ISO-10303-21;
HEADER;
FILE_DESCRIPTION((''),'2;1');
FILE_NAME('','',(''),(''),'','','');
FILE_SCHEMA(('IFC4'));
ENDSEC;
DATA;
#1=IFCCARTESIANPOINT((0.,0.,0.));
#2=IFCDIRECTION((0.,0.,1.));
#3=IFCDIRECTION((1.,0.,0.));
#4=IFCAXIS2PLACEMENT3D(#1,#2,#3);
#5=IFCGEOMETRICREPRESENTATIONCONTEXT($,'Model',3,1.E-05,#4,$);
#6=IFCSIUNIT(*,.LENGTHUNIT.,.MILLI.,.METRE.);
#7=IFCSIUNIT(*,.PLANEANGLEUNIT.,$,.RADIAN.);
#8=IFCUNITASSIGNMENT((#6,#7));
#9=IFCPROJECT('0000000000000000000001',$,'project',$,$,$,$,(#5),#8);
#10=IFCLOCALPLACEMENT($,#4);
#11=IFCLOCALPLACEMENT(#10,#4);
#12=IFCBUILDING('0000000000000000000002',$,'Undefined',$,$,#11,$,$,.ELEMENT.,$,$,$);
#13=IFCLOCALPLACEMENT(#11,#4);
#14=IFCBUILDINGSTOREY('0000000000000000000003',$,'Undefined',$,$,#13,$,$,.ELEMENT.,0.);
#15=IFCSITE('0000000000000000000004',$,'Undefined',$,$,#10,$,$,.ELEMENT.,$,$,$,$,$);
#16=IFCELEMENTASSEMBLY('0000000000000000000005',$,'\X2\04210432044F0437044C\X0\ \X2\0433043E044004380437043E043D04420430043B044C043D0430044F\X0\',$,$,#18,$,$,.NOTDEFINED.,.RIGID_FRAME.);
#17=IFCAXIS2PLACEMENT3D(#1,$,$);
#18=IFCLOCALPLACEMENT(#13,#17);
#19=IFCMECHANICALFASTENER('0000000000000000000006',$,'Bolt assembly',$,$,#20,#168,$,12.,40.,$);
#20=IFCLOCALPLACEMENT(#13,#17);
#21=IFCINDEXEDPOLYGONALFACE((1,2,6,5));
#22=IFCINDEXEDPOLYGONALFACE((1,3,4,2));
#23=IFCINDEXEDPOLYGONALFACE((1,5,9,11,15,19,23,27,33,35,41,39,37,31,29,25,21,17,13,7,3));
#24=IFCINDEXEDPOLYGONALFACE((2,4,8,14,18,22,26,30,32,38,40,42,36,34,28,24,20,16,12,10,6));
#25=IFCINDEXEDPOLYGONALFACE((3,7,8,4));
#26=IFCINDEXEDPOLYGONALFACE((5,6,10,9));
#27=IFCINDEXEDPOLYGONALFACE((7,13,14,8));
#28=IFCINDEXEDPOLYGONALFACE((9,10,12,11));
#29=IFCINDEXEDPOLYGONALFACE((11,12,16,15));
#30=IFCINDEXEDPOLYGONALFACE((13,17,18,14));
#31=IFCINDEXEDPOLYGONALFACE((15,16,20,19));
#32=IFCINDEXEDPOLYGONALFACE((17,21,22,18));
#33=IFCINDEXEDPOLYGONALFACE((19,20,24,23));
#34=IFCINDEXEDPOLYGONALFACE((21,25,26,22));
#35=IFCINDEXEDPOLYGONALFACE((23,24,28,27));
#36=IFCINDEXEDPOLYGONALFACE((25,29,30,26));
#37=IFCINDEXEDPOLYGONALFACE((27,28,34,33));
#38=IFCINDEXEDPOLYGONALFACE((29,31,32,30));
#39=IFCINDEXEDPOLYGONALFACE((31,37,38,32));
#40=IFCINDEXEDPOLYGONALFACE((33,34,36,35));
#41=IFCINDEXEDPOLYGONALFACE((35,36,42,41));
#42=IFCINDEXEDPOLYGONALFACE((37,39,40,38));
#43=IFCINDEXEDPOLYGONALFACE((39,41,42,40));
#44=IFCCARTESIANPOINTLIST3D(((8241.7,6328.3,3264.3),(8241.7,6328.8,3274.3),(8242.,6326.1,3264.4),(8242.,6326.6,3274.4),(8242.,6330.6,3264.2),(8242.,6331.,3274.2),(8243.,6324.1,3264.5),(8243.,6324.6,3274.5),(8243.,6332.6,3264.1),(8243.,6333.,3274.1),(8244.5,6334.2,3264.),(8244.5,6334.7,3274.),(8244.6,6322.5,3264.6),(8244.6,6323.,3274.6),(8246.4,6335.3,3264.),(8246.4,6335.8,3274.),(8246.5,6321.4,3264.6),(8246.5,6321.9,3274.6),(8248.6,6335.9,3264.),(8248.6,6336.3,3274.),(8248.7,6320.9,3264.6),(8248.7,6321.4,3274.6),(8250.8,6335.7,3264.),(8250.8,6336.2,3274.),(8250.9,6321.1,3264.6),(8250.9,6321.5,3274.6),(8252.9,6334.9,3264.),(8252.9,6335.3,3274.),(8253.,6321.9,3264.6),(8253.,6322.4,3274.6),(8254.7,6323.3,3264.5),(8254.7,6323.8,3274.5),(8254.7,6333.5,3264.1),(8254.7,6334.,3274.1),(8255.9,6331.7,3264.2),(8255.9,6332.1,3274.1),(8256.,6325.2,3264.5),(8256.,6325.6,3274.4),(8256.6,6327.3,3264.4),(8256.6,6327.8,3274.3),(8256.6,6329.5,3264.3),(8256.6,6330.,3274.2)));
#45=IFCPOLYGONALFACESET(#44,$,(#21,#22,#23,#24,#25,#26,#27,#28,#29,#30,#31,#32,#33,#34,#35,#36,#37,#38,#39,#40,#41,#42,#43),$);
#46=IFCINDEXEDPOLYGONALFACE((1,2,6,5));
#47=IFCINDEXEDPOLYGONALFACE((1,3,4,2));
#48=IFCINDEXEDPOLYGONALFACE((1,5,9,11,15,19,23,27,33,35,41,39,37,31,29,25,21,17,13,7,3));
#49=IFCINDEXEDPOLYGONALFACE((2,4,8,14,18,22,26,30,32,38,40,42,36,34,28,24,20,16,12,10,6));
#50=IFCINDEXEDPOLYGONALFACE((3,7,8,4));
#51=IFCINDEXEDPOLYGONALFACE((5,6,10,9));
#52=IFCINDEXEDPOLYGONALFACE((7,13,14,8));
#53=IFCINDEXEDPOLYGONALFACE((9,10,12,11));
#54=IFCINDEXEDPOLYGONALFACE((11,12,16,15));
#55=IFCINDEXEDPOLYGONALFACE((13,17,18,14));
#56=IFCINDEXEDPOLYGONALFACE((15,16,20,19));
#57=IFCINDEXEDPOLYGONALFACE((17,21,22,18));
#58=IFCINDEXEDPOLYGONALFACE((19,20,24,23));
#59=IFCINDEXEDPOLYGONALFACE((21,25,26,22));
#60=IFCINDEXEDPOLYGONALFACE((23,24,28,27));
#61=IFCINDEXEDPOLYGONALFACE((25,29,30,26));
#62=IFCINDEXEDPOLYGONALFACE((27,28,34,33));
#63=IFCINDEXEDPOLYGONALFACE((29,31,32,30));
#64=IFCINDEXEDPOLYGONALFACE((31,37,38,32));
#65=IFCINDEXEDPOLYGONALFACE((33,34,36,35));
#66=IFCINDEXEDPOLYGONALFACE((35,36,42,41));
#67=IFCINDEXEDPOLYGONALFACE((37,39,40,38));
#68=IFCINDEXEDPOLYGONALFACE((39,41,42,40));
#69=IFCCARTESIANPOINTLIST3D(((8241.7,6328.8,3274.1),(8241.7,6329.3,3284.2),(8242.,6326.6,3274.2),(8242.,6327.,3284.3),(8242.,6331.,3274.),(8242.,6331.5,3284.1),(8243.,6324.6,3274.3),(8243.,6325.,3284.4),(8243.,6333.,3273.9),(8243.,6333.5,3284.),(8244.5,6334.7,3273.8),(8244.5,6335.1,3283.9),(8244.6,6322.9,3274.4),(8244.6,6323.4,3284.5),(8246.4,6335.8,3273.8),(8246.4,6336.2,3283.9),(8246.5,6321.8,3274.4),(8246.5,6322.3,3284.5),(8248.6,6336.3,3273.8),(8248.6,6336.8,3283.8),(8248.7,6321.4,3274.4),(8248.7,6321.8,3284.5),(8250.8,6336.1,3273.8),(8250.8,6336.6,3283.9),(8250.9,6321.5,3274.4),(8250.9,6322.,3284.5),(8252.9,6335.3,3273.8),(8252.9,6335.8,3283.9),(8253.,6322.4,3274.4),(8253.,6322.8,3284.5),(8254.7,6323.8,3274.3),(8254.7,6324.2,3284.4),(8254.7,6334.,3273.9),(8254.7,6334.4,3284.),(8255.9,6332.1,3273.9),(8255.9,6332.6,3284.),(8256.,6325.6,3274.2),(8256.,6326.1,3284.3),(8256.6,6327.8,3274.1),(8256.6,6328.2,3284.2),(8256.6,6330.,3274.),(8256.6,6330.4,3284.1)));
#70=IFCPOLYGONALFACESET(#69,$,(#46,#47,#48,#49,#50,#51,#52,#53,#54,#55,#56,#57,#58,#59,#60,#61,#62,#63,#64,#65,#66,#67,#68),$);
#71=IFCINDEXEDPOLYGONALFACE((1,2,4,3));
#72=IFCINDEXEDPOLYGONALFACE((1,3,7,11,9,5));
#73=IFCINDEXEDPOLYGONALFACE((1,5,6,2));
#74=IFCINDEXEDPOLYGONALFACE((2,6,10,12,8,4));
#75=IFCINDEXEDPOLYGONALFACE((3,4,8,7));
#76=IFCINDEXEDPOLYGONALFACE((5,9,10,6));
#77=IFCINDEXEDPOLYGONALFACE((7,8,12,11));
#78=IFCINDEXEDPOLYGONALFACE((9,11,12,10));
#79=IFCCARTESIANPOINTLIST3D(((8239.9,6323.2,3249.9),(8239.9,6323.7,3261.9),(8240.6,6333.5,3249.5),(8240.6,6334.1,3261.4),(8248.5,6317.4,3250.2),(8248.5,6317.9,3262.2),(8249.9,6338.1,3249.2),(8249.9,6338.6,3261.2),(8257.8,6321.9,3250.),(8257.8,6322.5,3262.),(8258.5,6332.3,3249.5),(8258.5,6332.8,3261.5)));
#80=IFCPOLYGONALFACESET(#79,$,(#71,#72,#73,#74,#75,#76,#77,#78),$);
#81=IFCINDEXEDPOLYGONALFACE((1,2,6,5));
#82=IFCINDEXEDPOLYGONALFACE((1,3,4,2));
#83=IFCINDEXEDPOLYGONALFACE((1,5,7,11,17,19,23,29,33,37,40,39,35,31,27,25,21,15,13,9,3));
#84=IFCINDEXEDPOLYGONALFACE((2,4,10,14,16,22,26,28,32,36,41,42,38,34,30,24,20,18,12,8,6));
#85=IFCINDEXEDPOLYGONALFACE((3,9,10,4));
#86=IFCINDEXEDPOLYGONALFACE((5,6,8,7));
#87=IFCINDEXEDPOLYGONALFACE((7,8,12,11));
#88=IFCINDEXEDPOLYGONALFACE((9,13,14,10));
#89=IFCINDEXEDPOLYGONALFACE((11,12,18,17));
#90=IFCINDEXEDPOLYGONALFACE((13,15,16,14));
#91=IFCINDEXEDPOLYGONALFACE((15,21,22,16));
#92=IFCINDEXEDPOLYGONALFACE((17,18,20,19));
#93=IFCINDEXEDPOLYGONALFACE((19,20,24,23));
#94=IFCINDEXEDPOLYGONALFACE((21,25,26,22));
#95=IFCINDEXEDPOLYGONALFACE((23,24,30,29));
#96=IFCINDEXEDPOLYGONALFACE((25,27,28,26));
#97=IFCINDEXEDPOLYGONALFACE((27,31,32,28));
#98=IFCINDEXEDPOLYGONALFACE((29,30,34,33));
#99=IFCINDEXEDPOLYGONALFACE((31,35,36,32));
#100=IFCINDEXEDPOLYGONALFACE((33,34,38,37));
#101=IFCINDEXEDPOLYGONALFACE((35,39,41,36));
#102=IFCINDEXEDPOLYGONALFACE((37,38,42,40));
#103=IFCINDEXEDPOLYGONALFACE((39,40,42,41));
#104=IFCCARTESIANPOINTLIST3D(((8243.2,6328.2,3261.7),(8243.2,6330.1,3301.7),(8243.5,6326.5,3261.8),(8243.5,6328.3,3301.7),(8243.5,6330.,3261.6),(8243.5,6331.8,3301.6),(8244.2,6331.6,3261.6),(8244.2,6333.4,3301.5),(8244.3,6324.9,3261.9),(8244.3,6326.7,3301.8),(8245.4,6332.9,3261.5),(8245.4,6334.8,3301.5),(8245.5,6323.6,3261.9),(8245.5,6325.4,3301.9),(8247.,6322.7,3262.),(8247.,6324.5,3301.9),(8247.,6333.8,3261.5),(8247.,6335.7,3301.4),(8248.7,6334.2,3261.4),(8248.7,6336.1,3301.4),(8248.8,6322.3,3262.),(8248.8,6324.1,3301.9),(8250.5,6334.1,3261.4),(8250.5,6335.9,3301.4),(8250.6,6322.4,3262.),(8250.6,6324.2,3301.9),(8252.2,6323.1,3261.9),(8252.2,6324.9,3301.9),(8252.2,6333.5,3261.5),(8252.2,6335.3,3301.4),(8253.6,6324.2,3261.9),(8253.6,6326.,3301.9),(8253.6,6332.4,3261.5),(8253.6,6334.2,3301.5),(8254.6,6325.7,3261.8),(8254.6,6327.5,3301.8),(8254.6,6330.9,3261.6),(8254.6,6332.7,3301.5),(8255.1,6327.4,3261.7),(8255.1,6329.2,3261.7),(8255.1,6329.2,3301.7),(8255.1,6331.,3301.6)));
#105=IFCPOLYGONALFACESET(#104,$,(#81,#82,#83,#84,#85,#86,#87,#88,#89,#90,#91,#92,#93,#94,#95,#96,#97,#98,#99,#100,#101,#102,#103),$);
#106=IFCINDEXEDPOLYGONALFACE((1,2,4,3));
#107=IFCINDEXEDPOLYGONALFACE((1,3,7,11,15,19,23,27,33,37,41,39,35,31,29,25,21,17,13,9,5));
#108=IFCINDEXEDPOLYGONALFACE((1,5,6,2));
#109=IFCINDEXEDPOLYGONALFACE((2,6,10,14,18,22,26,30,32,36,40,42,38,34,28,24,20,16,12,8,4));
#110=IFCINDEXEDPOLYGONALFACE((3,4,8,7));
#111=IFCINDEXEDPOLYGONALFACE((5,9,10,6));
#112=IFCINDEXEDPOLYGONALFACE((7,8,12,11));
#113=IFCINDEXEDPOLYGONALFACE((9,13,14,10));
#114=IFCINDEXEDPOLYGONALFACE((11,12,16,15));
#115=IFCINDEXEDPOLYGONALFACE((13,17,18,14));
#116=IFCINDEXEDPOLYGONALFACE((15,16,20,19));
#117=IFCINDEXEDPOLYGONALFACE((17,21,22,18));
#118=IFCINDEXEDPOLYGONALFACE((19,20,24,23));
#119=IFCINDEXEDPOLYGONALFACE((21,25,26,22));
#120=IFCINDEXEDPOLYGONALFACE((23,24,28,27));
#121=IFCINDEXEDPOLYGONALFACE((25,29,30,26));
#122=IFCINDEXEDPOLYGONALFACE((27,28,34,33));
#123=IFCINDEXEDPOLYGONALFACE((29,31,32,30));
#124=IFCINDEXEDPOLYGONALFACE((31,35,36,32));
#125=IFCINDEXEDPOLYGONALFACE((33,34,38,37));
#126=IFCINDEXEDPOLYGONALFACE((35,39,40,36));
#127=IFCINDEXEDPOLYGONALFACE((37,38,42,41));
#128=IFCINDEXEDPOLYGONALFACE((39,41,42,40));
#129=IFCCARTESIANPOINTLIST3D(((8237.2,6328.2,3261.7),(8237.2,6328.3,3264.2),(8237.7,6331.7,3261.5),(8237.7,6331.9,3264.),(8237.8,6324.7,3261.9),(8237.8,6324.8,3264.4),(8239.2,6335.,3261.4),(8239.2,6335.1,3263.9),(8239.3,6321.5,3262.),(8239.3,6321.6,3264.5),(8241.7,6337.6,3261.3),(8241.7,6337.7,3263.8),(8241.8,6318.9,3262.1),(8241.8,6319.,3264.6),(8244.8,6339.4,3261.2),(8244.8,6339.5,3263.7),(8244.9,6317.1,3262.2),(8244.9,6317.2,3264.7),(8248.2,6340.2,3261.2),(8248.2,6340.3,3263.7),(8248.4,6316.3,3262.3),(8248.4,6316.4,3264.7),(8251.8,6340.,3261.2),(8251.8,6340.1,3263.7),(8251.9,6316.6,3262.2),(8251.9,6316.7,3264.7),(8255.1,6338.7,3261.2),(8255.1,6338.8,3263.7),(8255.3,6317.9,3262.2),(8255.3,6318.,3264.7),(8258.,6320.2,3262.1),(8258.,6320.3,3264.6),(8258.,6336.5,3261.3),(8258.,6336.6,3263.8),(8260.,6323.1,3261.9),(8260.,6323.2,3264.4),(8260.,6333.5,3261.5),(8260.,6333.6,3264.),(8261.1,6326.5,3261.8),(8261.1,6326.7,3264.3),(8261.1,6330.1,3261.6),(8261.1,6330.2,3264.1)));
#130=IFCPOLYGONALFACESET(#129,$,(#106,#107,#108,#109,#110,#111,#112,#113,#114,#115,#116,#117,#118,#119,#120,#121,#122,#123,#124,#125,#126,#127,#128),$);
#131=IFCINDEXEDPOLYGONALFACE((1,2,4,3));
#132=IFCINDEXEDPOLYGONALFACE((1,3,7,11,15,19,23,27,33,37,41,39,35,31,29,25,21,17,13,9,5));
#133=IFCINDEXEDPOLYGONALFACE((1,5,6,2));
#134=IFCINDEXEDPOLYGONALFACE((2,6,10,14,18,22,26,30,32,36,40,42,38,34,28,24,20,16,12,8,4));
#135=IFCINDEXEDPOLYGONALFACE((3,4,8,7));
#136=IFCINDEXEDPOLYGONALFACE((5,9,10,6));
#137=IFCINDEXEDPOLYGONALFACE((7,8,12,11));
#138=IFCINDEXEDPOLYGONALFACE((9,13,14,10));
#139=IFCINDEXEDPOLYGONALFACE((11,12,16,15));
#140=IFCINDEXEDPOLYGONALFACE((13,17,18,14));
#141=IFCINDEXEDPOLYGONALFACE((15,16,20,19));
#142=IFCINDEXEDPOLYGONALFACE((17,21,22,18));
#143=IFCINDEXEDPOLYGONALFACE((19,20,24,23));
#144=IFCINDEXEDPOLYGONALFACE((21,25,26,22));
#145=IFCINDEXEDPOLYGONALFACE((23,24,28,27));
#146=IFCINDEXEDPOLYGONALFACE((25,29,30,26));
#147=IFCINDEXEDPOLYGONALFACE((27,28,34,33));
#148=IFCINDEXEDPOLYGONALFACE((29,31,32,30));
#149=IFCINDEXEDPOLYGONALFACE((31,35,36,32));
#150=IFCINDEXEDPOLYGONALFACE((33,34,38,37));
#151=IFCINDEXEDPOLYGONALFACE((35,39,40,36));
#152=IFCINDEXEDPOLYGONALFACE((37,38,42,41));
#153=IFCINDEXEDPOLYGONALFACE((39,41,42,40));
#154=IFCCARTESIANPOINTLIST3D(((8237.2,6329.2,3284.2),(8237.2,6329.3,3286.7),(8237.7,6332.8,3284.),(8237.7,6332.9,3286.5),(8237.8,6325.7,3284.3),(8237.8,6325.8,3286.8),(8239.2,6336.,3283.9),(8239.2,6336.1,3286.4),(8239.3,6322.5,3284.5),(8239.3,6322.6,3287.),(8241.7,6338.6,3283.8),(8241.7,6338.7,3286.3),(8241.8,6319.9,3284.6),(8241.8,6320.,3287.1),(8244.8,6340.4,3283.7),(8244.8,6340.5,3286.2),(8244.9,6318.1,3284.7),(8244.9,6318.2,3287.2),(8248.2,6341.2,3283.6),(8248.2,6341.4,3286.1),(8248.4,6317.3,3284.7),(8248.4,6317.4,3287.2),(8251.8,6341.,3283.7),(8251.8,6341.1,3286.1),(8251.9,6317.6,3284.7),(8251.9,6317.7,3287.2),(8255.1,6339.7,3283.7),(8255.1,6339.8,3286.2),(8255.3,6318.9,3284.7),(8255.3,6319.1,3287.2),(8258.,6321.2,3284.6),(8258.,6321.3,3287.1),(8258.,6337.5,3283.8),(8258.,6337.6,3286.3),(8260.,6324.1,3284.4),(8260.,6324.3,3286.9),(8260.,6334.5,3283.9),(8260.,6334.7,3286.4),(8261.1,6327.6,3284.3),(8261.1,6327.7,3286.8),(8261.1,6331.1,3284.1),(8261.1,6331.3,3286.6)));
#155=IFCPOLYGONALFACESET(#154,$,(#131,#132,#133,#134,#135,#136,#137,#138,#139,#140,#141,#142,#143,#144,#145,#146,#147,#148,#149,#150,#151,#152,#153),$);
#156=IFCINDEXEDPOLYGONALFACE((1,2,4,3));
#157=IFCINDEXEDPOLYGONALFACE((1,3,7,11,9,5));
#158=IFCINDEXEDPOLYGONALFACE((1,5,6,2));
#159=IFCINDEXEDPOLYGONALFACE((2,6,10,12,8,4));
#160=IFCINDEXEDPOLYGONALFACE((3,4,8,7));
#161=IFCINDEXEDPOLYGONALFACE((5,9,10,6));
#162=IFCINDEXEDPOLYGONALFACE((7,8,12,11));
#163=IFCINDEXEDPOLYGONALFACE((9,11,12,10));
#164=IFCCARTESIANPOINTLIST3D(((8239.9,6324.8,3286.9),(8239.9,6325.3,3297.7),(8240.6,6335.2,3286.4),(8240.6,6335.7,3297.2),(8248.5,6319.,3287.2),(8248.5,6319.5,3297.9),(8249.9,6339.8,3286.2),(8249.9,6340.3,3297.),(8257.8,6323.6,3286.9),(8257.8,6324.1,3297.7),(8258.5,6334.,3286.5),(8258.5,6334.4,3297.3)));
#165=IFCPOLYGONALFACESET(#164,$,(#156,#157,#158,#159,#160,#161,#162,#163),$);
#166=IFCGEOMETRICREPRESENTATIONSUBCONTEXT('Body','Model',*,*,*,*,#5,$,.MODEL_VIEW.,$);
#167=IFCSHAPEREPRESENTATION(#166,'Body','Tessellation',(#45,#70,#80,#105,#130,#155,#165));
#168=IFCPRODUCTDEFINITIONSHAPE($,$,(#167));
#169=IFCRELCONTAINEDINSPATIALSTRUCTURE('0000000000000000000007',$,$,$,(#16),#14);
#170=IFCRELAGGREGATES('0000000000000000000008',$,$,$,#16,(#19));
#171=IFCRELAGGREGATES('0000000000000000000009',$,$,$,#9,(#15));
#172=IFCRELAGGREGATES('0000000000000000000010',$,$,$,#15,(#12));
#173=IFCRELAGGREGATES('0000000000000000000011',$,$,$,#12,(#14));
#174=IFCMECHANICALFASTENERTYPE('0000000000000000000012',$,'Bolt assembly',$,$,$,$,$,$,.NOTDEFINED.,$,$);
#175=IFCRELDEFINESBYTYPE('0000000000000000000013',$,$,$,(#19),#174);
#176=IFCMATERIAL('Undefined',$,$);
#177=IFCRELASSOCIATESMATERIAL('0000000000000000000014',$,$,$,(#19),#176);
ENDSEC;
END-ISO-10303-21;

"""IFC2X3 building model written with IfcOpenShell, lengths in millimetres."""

from ifc_helpers import new_model, si_unit, frame, origin_with_axes, origin_2d_with_axis, place, context, subcontext, project, spatial, polyline, circle, outline, extrude, source, transform, mapped, material, type_object, element, aggregate, save


model = new_model("IFC2X3")

# Units and contexts
model_context = context("Model", 3, precision=1e-05, world=origin_with_axes())
body_context = subcontext(model_context, "Body", "Model", "MODEL_VIEW")
ifc_project = project(units=[si_unit("LENGTHUNIT", "METRE", prefix="MILLI"), si_unit("PLANEANGLEUNIT", "RADIAN")], contexts=[model_context])

# Site, building, storey
site_placement = place(None, origin_with_axes())
site = spatial("IfcSite", under=ifc_project, at=site_placement, Name="Undefined", CompositionType="ELEMENT")
building_placement = place(site_placement, origin_with_axes())
building = spatial("IfcBuilding", under=site, at=building_placement, Name="Undefined", CompositionType="ELEMENT")
storey_placement = place(building_placement, origin_with_axes())
storey = spatial("IfcBuildingStorey", under=building, at=storey_placement, Name="Undefined", CompositionType="ELEMENT", Elevation=0.0)

# Element assembly
assembly_1_placement = place(storey_placement, origin_with_axes())
assembly_1 = element("IfcElementAssembly", 1, at=assembly_1_placement, inside=storey, Name="Связь горизонтальная", AssemblyPlace="NOTDEFINED", PredefinedType="RIGID_FRAME")

# Mechanical fastener
ifc_material_1 = material(Name="Undefined")
mechanical_fastener_type = type_object("IfcMechanicalFastenerType", Name="Bolt assembly")
shared_shape_1 = source(origin_with_axes(), body_context, "Body", "SweptSolid", [
    extrude(circle(Radius=7.5, at=origin_2d_with_axis()), frame((0.0, 0.1, 0.0), z_axis=(0.0, 1.0, 0.0), x_axis=(1.0, 0.0, 0.0)), (0.0, 0.0, 1.0), 10.0),
    extrude(circle(Radius=7.5, at=origin_2d_with_axis()), frame((0.0, 9.9, 0.0), z_axis=(0.0, 1.0, 0.0), x_axis=(1.0, 0.0, 0.0)), (0.0, 0.0, 1.0), 10.1),
    extrude(outline(polyline([(10.4, 0.0), (5.2, 9.0), (-5.2, 9.0), (-10.4, 0.0), (-5.2, -9.0), (5.2, -9.0), (10.4, 0.0)])), frame((0.0, -14.5, 0.0), z_axis=(0.0, 1.0, 0.0), x_axis=(1.0, 0.0, 0.0)), (0.0, 0.0, 1.0), 12.0),
    extrude(circle(Radius=6.0, at=origin_2d_with_axis()), frame((0.0, -2.5, 0.0), z_axis=(0.0, 1.0, 0.0), x_axis=(1.0, 0.0, 0.0)), (0.0, 0.0, 1.0), 40.0),
    extrude(circle(Radius=12.0, at=origin_2d_with_axis()), frame((0.0, -2.5, 0.0), z_axis=(0.0, 1.0, 0.0), x_axis=(1.0, 0.0, 0.0)), (0.0, 0.0, 1.0), 2.5),
    extrude(circle(Radius=12.0, at=origin_2d_with_axis()), frame((0.0, 20.0, 0.0), z_axis=(0.0, 1.0, 0.0), x_axis=(1.0, 0.0, 0.0)), (0.0, 0.0, 1.0), 2.5),
    extrude(outline(polyline([(10.4, 0.0), (5.2, 9.0), (-5.2, 9.0), (-10.4, 0.0), (-5.2, -9.0), (5.2, -9.0), (10.4, 0.0)])), frame((0.0, 22.5, 0.0), z_axis=(0.0, 1.0, 0.0), x_axis=(1.0, 0.0, 0.0)), (0.0, 0.0, 1.0), 10.8),
])
mechanical_fastener_1_placement = place(assembly_1_placement, frame((8249.2, 6328.4, 3264.2), z_axis=(0.558918, 0.828367, -0.037653), x_axis=(-0.829223, 0.558342, -0.025379)))
mechanical_fastener_1 = element("IfcMechanicalFastener", 2, at=mechanical_fastener_1_placement, type_object=mechanical_fastener_type, material=ifc_material_1, Name="Bolt assembly", NominalDiameter=12.0, NominalLength=40.0, context=body_context, shape_type="MappedRepresentation", body=[
    mapped(shared_shape_1, transform((0.0, 0.0, 0.0))),
])
aggregate(assembly_1, [mechanical_fastener_1])

save(model, "model.ifc")
